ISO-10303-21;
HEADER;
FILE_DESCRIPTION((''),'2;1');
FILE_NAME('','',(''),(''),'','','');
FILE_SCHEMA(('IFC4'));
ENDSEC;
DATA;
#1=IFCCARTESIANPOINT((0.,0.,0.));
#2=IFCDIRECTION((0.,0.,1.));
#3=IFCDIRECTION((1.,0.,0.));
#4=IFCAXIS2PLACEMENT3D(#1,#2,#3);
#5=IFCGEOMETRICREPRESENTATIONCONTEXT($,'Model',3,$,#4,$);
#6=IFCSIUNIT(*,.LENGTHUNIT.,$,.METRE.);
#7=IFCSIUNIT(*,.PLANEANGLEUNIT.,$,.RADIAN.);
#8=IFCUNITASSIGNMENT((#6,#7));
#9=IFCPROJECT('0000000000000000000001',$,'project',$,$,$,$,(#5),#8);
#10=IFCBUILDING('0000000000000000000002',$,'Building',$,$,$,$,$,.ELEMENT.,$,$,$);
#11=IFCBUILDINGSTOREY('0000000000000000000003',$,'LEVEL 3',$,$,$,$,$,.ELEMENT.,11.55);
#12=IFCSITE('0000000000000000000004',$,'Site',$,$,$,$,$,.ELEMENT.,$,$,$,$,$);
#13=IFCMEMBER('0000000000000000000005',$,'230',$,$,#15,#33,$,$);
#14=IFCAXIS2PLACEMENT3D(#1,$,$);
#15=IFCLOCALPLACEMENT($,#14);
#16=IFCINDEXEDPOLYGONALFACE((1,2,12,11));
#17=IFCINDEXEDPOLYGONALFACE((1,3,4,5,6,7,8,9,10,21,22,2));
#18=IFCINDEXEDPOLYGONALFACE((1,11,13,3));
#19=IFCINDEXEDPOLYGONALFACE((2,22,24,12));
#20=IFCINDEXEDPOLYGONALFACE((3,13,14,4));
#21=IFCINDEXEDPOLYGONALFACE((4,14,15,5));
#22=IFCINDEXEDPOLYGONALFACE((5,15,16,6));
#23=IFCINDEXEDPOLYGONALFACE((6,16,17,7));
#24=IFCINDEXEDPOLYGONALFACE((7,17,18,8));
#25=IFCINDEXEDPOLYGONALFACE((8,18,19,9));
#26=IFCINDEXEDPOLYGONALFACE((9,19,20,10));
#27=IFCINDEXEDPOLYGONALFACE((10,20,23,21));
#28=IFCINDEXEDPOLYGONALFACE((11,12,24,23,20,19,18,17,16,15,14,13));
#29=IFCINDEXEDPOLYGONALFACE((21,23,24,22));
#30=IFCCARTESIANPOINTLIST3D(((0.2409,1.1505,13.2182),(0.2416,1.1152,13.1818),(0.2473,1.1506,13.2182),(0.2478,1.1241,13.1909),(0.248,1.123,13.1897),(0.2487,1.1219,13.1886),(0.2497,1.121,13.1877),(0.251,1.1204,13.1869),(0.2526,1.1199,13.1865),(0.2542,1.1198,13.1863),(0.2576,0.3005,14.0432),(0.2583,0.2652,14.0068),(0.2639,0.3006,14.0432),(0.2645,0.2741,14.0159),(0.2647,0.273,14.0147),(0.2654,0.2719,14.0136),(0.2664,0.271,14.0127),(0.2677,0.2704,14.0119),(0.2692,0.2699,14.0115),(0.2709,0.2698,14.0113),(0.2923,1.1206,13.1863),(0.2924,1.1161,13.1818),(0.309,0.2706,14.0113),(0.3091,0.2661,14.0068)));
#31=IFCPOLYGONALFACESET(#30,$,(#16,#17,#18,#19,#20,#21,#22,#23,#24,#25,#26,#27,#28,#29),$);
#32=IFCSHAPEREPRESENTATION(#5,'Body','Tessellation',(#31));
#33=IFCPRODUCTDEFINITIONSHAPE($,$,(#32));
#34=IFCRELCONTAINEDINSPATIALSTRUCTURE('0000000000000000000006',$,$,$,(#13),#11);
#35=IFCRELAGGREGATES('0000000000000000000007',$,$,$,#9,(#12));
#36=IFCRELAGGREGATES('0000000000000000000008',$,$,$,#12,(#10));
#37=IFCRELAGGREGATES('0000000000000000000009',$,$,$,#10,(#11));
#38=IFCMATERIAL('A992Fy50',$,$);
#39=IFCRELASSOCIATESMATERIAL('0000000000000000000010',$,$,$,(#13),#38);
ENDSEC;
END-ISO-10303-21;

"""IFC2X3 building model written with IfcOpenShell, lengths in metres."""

from ifc_helpers import new_model, si_unit, frame, origin_with_axes, origin_2d_with_axis, place, context, project, spatial, l_section, extrude, material, element, save


model = new_model("IFC2X3")

# Units and contexts
model_context = context("Model", 3, world=origin_with_axes())
ifc_project = project(units=[si_unit("LENGTHUNIT", "METRE"), si_unit("PLANEANGLEUNIT", "RADIAN")], contexts=[model_context])

# Site, building, storey
site = spatial("IfcSite", under=ifc_project, Name="Site", CompositionType="ELEMENT")
building = spatial("IfcBuilding", under=site, Name="Building", CompositionType="ELEMENT")
storey = spatial("IfcBuildingStorey", under=building, Name="LEVEL 3", CompositionType="ELEMENT", Elevation=11.55)

# Shared definitions
ifc_material = material(Name="A992Fy50")

# Member
member_1_placement = place(None, frame((0.2667, 1.1333, 13.2), z_axis=(0.014069, -0.71751, 0.696406), x_axis=(0.999808, 0.019604, 0.0)))
element("IfcMember", 1, at=member_1_placement, inside=storey, material=ifc_material, Name="230", context=model_context, shape_type="SweptSolid", body=[
    extrude(l_section(Depth=0.0508, Width=0.0508, Thickness=0.0063, FilletRadius=0.0063, at=origin_2d_with_axis()), origin_with_axes(), (0.0, 0.0, 1.0), 1.1847),
])

save(model, "model.ifc")
